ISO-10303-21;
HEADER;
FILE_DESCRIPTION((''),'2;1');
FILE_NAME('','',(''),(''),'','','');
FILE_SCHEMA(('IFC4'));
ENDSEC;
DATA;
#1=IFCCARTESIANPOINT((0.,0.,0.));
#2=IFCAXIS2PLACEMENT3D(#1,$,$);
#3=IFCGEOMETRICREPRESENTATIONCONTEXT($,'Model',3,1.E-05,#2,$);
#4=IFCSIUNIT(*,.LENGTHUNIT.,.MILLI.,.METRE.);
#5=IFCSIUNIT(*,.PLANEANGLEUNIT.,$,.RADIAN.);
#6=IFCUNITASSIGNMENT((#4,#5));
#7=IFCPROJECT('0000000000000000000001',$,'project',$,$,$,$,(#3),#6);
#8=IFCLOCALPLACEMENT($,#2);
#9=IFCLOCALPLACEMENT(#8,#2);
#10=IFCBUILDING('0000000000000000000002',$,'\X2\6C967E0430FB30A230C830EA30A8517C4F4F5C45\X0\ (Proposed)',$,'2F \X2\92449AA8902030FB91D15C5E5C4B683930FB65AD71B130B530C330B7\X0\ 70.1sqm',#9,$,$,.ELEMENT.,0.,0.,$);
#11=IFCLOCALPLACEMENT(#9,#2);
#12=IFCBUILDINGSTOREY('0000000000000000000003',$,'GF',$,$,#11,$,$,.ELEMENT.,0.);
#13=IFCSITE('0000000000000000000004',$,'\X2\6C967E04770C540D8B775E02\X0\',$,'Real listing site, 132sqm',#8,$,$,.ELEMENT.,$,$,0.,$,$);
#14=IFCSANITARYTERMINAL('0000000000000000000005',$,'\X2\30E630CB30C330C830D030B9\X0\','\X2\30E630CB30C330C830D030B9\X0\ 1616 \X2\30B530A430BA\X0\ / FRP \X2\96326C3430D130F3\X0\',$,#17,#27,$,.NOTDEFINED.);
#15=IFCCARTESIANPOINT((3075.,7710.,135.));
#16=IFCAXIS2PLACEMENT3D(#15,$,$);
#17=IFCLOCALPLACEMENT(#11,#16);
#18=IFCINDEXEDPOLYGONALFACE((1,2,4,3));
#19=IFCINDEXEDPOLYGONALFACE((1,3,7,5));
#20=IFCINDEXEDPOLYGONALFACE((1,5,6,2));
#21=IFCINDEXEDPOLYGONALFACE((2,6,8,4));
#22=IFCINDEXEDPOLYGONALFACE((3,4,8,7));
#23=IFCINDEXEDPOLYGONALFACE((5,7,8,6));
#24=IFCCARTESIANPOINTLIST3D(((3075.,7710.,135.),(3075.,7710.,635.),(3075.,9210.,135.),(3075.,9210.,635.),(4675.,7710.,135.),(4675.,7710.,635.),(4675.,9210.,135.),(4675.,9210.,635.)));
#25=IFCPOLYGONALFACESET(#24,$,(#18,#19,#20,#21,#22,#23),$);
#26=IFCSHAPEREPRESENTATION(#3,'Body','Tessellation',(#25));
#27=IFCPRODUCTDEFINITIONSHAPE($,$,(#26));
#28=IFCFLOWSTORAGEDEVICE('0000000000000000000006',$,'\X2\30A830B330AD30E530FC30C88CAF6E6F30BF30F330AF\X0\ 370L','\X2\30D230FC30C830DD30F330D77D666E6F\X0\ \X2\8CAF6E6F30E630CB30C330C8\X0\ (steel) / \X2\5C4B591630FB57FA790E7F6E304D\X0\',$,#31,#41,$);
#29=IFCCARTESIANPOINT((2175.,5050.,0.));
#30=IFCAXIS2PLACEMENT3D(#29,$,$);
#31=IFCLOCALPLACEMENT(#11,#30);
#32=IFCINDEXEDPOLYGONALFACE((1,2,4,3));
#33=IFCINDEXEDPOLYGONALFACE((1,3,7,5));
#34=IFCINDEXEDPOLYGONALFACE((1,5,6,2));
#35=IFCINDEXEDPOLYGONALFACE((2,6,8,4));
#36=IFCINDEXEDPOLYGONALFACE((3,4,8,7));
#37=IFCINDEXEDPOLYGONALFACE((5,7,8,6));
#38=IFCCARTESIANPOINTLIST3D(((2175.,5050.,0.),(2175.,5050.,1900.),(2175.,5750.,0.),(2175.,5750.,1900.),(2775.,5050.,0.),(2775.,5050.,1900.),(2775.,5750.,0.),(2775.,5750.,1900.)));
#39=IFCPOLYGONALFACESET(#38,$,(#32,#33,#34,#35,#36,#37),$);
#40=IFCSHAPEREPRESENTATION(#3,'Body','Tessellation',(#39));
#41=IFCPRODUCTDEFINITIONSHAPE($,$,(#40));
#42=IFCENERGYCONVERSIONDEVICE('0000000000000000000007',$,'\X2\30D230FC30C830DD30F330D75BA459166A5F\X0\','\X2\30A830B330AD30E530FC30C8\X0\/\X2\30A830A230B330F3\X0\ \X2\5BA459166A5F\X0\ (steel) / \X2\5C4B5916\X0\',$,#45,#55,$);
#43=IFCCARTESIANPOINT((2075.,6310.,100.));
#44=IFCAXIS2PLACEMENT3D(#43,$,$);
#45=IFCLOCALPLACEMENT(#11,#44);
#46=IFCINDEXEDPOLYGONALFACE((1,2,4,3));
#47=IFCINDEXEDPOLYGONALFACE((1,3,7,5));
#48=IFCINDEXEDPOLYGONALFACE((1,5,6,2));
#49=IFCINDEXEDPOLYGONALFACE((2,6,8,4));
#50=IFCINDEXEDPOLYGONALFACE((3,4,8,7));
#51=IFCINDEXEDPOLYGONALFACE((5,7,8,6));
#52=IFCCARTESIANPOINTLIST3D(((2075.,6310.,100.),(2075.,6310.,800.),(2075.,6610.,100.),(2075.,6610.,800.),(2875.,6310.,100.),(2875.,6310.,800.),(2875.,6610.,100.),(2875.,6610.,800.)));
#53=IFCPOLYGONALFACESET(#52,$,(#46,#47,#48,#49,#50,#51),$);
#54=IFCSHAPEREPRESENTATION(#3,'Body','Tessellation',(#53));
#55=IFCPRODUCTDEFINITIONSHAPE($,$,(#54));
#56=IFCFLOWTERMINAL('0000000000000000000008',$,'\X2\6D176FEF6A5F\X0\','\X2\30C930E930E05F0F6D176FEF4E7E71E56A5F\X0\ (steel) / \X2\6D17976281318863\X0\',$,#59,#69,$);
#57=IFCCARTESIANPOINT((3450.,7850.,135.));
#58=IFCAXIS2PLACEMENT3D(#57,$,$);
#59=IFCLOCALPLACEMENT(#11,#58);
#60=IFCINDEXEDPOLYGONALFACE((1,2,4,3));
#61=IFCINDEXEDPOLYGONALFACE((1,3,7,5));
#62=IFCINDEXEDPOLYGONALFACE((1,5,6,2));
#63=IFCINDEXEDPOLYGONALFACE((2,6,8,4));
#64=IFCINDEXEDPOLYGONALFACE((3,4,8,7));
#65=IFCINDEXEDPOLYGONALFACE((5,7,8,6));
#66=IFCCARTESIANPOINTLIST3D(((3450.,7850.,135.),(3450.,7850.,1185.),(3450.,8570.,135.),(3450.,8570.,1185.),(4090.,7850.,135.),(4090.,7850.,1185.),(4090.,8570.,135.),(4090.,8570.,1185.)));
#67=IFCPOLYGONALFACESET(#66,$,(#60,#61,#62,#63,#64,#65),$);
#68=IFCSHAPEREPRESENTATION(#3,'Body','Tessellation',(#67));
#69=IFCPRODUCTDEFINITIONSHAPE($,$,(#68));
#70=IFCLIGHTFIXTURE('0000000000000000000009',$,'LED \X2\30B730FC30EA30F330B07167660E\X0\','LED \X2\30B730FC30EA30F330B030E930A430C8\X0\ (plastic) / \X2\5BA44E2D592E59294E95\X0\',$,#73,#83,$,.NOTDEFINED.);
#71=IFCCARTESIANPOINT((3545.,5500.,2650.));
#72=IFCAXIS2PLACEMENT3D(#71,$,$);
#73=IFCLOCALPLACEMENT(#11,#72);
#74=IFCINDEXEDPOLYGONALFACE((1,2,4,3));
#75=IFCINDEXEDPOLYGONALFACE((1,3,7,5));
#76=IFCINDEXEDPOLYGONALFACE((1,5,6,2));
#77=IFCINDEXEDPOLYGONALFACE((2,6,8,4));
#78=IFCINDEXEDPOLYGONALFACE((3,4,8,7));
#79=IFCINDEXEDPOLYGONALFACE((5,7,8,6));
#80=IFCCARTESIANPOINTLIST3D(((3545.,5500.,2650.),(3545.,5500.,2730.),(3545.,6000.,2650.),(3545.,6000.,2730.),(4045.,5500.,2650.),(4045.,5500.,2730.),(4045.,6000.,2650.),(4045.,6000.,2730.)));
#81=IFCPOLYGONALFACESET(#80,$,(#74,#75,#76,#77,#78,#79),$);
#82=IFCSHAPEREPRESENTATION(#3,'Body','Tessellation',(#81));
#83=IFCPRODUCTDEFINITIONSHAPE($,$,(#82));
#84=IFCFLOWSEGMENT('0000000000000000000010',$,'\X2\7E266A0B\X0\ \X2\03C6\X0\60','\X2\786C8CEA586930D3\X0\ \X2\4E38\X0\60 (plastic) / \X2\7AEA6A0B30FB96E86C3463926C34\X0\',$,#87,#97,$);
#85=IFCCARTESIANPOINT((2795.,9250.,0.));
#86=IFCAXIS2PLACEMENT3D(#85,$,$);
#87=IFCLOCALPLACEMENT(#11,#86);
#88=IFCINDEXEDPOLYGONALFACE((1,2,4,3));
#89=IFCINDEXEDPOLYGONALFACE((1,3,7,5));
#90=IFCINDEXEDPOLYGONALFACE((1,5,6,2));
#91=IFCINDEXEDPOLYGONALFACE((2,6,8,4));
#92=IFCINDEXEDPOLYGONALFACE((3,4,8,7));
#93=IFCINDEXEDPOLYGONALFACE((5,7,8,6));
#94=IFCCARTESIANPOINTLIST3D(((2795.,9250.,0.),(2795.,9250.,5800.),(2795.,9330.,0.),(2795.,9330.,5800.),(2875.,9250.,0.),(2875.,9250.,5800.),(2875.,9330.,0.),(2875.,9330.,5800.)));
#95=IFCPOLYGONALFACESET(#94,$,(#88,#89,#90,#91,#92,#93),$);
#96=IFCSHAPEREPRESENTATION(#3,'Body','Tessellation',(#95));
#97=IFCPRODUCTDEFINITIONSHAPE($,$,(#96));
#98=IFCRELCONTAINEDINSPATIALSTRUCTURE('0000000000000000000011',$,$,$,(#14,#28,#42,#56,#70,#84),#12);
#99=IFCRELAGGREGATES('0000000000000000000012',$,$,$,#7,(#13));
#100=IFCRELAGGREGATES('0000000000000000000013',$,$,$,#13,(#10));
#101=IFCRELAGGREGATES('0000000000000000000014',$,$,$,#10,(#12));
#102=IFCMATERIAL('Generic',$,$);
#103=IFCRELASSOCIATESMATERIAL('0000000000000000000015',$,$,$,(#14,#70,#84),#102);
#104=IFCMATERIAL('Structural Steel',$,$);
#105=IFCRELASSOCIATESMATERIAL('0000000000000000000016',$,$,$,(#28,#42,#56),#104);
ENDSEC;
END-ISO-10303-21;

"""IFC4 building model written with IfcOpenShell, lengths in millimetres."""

from ifc_helpers import new_model, si_unit, frame, frame_2d, origin, place, context, project, spatial, rectangle, extrude, material, element, save


model = new_model("IFC4")

# Units and contexts
model_context = context("Model", 3, precision=1e-05, world=origin())
ifc_project = project(units=[si_unit("LENGTHUNIT", "METRE", prefix="MILLI"), si_unit("PLANEANGLEUNIT", "RADIAN")], contexts=[model_context])

# Site, building, storey
site_placement = place(None, origin())
site = spatial("IfcSite", under=ifc_project, at=site_placement, Name="沖縄県名護市", ObjectType="Real listing site, 132sqm", CompositionType="ELEMENT", RefElevation=0.0)
building_placement = place(site_placement, origin())
building = spatial("IfcBuilding", under=site, at=building_placement, Name="沖縄・アトリエ兼住居 (Proposed)", ObjectType="2F 鉄骨造・金属屋根・断熱サッシ 70.1sqm", CompositionType="ELEMENT", ElevationOfRefHeight=0.0, ElevationOfTerrain=0.0)
storey_placement = place(building_placement, origin())
storey = spatial("IfcBuildingStorey", under=building, at=storey_placement, Name="GF", CompositionType="ELEMENT", Elevation=0.0)

# Shared definitions
ifc_material_1 = material(Name="Generic")

# Sanitary terminal
sanitary_terminal_placement = place(storey_placement, frame((3075.0, 7710.0, 135.0)))
element("IfcSanitaryTerminal", 1, at=sanitary_terminal_placement, inside=storey, material=ifc_material_1, Name="ユニットバス", Description="ユニットバス 1616 サイズ / FRP 防水パン", PredefinedType="NOTDEFINED", context=model_context, shape_type="SweptSolid", body=[
    extrude(rectangle(XDim=1600.0, YDim=1500.0, at=frame_2d((800.0, 750.0))), frame((3075.0, 7710.0, 135.0)), (0.0, 0.0, 1.0), 500.0),
])

# Flow storage device
ifc_material_2 = material(Name="Structural Steel")
flow_storage_device_placement = place(storey_placement, frame((2175.0, 5050.0, 0.0)))
element("IfcFlowStorageDevice", 2, at=flow_storage_device_placement, inside=storey, material=ifc_material_2, Name="エコキュート貯湯タンク 370L", Description="ヒートポンプ給湯 貯湯ユニット (steel) / 屋外・基礎置き", context=model_context, shape_type="SweptSolid", body=[
    extrude(rectangle(XDim=600.0, YDim=700.0, at=frame_2d((300.0, 350.0))), frame((2175.0, 5050.0, 0.0)), (0.0, 0.0, 1.0), 1900.0),
])

# Energy conversion device
energy_conversion_device_placement = place(storey_placement, frame((2075.0, 6310.0, 100.0)))
element("IfcEnergyConversionDevice", 3, at=energy_conversion_device_placement, inside=storey, material=ifc_material_2, Name="ヒートポンプ室外機", Description="エコキュート/エアコン 室外機 (steel) / 屋外", context=model_context, shape_type="SweptSolid", body=[
    extrude(rectangle(XDim=800.0, YDim=300.0, at=frame_2d((400.0, 150.0))), frame((2075.0, 6310.0, 100.0)), (0.0, 0.0, 1.0), 700.0),
])

# Flow terminal
flow_terminal_placement = place(storey_placement, frame((3450.0, 7850.0, 135.0)))
element("IfcFlowTerminal", 4, at=flow_terminal_placement, inside=storey, material=ifc_material_2, Name="洗濯機", Description="ドラム式洗濯乾燥機 (steel) / 洗面脱衣", context=model_context, shape_type="SweptSolid", body=[
    extrude(rectangle(XDim=640.0, YDim=720.0, at=frame_2d((320.0, 360.0))), frame((3450.0, 7850.0, 135.0)), (0.0, 0.0, 1.0), 1050.0),
])

# Light fixture
light_fixture_placement = place(storey_placement, frame((3545.0, 5500.0, 2650.0)))
element("IfcLightFixture", 5, at=light_fixture_placement, inside=storey, material=ifc_material_1, Name="LED シーリング照明", Description="LED シーリングライト (plastic) / 室中央天井", PredefinedType="NOTDEFINED", context=model_context, shape_type="SweptSolid", body=[
    extrude(rectangle(XDim=500.0, YDim=500.0, at=frame_2d((250.0, 250.0))), frame((3545.0, 5500.0, 2650.0)), (0.0, 0.0, 1.0), 80.0),
])

# Flow segment
flow_segment_placement = place(storey_placement, frame((2795.0, 9250.0, 0.0)))
element("IfcFlowSegment", 6, at=flow_segment_placement, inside=storey, material=ifc_material_1, Name="縦樋 φ60", Description="硬質塩ビ 丸60 (plastic) / 竪樋・雨水排水", context=model_context, shape_type="SweptSolid", body=[
    extrude(rectangle(XDim=80.0, YDim=80.0, at=frame_2d((40.0, 40.0))), frame((2795.0, 9250.0, 0.0)), (0.0, 0.0, 1.0), 5800.0),
])

save(model, "model.ifc")
